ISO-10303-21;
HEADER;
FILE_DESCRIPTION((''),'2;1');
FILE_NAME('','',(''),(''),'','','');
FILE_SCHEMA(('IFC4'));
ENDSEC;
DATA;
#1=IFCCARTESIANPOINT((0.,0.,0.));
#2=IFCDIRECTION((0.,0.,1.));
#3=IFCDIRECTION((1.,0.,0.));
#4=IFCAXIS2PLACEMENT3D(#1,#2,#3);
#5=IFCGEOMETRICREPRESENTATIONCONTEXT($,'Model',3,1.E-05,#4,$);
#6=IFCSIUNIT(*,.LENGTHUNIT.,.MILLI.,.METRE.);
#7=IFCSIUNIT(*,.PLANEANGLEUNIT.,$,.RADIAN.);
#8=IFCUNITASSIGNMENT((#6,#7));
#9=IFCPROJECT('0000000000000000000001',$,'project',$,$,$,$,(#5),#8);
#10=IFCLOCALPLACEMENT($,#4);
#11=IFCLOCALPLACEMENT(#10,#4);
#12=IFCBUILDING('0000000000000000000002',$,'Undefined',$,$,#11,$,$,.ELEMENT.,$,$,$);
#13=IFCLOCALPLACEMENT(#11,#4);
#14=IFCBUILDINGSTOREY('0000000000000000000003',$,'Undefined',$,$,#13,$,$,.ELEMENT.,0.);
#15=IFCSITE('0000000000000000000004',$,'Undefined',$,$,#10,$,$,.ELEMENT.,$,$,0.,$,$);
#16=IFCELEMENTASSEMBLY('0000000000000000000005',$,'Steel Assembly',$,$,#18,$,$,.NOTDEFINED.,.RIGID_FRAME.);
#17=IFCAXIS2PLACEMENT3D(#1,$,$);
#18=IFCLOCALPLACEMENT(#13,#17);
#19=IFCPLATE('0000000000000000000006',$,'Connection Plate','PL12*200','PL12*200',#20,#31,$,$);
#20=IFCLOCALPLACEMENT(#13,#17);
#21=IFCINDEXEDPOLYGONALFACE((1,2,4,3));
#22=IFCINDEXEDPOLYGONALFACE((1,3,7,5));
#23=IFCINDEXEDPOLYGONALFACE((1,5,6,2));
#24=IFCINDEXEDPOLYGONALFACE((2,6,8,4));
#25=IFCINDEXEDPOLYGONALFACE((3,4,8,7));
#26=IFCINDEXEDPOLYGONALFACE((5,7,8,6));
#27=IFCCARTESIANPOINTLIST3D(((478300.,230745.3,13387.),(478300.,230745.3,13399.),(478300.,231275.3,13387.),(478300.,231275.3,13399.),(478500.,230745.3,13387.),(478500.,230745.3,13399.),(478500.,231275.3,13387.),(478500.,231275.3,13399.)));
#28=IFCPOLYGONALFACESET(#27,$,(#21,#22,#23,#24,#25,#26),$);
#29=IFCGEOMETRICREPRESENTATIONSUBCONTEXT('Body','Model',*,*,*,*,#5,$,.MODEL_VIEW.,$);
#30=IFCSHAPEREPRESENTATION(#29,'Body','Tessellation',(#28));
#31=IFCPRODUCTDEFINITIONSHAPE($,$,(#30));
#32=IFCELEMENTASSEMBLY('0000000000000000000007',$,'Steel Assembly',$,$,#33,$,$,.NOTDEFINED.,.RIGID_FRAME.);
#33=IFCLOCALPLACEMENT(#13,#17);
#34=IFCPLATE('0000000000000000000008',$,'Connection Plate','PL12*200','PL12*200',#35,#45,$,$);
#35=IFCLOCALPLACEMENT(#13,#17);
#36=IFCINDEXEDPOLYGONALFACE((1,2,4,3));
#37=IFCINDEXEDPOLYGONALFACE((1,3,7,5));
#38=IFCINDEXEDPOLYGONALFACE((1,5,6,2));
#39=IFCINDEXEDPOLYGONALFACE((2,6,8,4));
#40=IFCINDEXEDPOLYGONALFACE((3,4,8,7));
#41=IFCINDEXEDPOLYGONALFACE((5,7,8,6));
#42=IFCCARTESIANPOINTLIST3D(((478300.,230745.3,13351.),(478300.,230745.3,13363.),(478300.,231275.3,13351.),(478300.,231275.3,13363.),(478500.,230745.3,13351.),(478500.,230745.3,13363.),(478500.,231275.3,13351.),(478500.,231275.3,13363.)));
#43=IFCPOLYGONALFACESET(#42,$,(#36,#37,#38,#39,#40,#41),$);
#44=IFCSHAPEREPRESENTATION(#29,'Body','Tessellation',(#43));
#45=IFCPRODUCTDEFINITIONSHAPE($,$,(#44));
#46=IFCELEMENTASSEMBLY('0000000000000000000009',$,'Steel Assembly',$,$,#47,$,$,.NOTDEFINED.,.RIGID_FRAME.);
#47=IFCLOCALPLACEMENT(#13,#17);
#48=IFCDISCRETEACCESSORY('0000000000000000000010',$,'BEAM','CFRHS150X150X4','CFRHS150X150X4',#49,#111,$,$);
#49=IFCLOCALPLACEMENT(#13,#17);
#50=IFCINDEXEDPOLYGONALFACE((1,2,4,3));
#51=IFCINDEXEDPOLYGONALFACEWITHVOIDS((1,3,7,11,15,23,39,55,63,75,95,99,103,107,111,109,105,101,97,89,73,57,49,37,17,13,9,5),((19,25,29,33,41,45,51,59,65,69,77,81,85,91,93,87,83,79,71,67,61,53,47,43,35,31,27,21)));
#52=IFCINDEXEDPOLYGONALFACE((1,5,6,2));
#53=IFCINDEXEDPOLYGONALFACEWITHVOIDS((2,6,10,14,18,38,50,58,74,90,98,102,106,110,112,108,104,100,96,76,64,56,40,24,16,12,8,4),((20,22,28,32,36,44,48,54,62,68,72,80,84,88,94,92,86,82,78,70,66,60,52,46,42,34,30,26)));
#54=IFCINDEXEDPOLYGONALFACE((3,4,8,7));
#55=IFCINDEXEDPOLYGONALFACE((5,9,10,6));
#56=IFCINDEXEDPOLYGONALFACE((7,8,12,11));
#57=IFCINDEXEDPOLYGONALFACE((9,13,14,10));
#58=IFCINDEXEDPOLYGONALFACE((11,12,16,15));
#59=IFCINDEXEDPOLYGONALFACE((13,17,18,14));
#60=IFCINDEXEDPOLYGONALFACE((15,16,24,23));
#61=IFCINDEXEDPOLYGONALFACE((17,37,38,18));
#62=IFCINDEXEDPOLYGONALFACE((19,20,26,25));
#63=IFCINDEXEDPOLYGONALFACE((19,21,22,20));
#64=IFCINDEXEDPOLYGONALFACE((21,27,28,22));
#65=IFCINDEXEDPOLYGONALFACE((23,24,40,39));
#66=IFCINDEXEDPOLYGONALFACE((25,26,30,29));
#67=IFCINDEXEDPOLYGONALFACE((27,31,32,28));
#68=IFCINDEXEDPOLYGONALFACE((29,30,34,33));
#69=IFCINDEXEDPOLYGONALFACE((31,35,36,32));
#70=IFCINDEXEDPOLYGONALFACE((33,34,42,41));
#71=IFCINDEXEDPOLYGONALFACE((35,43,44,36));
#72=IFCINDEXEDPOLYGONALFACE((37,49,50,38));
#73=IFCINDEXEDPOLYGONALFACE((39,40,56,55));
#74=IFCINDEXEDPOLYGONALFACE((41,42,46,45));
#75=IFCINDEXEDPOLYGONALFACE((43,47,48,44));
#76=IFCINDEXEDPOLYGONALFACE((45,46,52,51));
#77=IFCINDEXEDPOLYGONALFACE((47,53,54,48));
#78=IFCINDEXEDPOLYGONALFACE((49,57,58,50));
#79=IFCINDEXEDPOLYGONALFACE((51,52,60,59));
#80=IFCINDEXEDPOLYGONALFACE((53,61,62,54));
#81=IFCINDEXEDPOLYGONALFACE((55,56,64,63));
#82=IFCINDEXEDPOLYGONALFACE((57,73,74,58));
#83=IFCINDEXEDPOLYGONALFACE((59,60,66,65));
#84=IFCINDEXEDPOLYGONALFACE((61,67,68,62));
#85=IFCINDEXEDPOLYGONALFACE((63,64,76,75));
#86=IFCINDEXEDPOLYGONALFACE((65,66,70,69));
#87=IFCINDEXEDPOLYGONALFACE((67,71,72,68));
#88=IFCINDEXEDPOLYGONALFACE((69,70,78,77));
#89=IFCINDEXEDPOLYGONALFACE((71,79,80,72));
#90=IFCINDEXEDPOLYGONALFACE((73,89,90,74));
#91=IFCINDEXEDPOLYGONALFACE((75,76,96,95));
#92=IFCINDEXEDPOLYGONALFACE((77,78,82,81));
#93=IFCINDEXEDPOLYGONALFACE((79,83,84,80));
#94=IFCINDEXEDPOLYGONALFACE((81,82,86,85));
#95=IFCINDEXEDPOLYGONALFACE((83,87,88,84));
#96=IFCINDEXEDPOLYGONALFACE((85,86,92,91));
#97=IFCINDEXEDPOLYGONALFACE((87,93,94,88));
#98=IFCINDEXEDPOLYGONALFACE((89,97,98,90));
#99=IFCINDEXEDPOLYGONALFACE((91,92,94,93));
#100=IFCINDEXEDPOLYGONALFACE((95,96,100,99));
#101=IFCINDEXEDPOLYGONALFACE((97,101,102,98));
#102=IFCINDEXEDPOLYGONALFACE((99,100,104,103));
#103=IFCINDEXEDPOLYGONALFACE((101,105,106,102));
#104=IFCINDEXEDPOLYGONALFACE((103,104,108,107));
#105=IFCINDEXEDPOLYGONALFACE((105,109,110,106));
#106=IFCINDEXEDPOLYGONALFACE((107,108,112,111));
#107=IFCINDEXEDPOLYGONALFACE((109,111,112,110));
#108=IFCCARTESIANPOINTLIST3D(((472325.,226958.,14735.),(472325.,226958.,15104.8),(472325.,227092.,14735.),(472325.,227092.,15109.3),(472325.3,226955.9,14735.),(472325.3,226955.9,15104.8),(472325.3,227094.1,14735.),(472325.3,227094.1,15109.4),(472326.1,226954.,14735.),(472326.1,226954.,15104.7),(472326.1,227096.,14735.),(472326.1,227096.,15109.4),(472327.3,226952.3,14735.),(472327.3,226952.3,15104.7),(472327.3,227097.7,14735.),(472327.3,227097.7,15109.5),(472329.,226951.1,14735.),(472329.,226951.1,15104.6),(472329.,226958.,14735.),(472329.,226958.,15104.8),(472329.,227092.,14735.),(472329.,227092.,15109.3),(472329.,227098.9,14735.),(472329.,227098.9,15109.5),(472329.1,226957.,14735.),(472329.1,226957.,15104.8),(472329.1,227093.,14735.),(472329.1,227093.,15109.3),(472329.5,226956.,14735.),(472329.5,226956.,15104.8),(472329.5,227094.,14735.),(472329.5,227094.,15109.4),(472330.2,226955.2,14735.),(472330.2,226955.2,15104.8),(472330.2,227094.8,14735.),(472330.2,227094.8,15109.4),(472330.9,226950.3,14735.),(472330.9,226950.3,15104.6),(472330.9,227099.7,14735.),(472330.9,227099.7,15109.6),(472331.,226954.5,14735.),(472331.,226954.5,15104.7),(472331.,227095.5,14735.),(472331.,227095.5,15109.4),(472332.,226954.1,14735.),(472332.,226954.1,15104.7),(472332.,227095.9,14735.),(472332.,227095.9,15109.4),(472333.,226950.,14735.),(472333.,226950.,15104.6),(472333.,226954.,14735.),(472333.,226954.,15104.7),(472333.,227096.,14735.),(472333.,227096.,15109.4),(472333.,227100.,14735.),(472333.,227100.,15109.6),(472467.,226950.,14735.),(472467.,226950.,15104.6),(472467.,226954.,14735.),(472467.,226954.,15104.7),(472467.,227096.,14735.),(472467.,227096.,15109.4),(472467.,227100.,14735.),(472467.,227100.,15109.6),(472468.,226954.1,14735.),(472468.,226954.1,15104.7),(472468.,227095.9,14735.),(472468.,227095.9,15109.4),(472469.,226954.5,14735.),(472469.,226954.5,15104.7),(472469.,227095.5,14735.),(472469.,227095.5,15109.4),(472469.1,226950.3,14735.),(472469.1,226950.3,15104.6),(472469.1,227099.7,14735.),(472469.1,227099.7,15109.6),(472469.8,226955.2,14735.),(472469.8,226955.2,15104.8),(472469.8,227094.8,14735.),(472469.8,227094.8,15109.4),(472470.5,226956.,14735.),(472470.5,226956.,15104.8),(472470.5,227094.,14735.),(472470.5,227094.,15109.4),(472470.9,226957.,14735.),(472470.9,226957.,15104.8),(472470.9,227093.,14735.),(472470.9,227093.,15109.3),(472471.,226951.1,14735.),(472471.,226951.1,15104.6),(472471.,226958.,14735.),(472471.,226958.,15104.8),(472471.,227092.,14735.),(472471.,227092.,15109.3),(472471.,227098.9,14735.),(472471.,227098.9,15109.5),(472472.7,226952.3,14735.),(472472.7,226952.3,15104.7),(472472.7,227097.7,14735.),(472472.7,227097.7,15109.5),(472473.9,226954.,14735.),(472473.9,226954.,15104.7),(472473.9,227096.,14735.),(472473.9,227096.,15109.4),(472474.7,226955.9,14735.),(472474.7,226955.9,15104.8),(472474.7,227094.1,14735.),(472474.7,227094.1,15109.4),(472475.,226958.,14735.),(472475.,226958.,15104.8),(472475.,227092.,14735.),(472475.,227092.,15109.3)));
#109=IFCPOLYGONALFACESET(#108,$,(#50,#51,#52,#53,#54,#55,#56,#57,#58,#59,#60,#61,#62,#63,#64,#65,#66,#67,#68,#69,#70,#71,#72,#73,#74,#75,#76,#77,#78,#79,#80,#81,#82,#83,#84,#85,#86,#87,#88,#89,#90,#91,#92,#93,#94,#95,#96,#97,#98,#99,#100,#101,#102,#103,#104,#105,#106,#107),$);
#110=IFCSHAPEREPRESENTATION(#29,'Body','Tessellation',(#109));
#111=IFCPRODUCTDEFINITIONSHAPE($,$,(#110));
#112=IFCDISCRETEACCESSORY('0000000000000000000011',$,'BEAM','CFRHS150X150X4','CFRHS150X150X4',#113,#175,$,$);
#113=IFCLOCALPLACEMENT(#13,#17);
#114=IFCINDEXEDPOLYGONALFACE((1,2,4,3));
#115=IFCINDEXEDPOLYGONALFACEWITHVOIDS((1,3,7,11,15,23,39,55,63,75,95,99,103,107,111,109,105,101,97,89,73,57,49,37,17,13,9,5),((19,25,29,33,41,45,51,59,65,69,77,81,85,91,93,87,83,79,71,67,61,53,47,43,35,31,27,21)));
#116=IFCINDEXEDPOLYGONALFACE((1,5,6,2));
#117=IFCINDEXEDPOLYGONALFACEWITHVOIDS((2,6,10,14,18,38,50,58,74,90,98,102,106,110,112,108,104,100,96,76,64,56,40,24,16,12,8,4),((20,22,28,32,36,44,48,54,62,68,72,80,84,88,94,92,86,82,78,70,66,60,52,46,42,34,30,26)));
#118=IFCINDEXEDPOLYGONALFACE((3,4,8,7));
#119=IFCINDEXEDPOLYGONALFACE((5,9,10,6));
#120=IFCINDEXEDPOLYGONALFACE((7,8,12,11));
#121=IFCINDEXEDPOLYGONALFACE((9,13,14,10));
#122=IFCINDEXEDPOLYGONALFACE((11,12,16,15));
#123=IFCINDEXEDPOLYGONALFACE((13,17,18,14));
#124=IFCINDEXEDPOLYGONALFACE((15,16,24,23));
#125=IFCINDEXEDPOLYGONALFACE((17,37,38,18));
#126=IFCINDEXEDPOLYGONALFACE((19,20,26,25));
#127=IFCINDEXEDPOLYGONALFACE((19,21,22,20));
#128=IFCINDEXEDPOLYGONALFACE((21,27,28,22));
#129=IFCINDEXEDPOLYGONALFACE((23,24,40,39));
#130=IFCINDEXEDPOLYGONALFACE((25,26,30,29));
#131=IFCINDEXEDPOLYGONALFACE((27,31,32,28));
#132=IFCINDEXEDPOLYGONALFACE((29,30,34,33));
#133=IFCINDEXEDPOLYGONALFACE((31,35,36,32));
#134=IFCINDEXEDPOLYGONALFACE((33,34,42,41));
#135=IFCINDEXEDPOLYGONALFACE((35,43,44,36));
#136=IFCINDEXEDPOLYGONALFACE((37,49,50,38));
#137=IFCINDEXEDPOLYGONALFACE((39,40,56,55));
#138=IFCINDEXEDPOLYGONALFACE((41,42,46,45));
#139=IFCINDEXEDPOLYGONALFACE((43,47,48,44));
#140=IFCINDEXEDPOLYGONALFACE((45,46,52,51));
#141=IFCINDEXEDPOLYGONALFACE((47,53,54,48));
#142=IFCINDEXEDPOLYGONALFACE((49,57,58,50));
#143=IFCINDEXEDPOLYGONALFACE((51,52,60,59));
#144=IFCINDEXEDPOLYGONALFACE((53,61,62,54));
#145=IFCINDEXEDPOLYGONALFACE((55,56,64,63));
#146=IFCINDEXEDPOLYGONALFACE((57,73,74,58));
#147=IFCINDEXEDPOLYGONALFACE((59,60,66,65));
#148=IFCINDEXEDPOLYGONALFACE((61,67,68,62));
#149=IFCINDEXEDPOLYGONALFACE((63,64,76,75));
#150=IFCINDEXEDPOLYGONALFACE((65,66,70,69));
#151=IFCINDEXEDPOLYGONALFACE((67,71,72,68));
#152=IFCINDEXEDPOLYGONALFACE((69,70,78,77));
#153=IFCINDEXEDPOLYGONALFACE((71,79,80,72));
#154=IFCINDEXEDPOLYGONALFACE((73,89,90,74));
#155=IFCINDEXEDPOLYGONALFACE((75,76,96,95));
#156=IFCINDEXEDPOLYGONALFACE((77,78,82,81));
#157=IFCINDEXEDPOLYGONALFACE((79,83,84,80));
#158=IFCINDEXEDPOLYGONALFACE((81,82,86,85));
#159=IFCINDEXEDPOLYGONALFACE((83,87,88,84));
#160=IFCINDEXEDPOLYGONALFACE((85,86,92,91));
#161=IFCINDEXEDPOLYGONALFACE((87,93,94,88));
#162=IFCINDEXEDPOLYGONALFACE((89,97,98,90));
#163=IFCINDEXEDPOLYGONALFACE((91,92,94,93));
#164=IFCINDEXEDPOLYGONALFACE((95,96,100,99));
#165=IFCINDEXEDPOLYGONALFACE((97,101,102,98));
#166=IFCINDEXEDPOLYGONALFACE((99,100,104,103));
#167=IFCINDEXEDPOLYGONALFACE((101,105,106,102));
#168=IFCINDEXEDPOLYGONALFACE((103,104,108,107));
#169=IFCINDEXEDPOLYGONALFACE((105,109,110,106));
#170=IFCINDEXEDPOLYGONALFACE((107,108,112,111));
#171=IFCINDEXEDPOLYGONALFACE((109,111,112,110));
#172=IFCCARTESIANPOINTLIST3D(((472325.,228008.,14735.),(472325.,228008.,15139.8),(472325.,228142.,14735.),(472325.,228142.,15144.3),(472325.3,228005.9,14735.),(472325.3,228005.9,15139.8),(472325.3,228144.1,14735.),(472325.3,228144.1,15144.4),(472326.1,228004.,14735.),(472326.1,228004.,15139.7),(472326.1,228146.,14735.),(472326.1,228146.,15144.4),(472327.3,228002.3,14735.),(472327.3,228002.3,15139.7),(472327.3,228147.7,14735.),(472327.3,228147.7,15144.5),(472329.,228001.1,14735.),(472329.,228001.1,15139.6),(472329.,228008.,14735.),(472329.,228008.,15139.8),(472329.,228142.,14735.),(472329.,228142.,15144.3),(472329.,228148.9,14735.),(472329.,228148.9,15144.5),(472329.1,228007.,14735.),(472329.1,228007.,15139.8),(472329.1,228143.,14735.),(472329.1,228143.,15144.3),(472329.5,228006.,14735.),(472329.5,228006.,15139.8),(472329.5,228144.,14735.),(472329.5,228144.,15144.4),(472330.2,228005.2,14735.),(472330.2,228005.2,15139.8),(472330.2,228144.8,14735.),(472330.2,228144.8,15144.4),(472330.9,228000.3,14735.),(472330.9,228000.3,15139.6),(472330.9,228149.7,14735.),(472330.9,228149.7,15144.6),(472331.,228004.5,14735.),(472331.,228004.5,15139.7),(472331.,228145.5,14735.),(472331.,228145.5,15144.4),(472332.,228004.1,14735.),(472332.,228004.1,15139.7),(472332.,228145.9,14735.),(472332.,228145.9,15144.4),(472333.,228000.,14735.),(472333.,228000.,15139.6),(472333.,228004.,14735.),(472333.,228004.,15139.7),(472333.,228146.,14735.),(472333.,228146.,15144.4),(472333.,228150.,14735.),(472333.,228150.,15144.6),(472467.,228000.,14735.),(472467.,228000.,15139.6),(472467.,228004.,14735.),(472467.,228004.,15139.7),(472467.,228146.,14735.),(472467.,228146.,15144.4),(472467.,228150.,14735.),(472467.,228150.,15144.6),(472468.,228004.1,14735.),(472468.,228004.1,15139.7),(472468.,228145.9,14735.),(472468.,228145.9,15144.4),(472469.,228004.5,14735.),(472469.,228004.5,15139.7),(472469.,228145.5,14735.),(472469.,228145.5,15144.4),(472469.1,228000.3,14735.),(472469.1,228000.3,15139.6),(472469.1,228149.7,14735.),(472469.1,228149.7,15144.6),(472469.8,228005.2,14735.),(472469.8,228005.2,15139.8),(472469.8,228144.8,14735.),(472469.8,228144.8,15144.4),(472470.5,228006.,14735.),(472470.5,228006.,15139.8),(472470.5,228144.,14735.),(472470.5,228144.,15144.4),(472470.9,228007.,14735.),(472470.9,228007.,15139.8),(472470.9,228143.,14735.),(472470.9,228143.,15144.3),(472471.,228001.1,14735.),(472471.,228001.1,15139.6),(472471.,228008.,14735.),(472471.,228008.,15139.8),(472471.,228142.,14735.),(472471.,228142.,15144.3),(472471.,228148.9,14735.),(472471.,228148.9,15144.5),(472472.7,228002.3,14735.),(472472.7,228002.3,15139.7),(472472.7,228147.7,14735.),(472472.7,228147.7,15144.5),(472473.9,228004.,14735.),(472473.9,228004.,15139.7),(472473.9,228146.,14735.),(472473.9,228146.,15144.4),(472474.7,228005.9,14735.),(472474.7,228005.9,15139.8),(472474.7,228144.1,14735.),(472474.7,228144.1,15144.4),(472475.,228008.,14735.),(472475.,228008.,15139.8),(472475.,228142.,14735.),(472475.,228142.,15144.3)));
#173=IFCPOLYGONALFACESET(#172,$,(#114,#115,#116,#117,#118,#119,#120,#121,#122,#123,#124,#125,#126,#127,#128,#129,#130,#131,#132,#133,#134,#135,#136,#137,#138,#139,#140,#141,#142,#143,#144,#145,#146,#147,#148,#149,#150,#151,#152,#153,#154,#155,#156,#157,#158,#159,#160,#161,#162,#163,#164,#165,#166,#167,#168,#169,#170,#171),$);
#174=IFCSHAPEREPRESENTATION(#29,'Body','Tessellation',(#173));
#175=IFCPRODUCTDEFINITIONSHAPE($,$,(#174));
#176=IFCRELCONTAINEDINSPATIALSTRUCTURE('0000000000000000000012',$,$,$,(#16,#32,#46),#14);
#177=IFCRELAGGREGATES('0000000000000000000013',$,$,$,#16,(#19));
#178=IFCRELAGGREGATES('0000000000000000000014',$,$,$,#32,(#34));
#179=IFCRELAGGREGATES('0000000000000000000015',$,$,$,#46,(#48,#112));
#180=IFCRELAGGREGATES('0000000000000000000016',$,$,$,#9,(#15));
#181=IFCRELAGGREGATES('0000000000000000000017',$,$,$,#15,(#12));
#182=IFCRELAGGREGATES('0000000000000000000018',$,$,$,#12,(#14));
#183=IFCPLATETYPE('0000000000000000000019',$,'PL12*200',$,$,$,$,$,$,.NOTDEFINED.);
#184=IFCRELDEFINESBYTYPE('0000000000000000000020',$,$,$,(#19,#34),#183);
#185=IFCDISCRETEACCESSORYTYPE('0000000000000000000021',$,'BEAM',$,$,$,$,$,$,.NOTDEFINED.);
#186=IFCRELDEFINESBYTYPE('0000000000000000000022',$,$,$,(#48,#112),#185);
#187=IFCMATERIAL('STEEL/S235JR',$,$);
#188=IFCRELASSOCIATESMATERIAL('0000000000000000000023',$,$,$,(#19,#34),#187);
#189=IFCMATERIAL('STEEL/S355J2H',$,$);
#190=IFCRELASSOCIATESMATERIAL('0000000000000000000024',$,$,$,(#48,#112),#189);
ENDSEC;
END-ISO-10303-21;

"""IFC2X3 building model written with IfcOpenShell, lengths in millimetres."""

from ifc_helpers import new_model, si_unit, frame, origin_with_axes, origin_2d_with_axis, place, context, subcontext, project, spatial, polyline, hollow_rectangle, outline, extrude, clip, halfspace, material, type_object, element, aggregate, save


model = new_model("IFC2X3")

# Units and contexts
model_context = context("Model", 3, precision=1e-05, world=origin_with_axes())
body_context = subcontext(model_context, "Body", "Model", "MODEL_VIEW")
ifc_project = project(units=[si_unit("LENGTHUNIT", "METRE", prefix="MILLI"), si_unit("PLANEANGLEUNIT", "RADIAN")], contexts=[model_context])

# Site, building, storey
site_placement = place(None, origin_with_axes())
site = spatial("IfcSite", under=ifc_project, at=site_placement, Name="Undefined", CompositionType="ELEMENT", RefElevation=0.0)
building_placement = place(site_placement, origin_with_axes())
building = spatial("IfcBuilding", under=site, at=building_placement, Name="Undefined", CompositionType="ELEMENT")
storey_placement = place(building_placement, origin_with_axes())
storey = spatial("IfcBuildingStorey", under=building, at=storey_placement, Name="Undefined", CompositionType="ELEMENT", Elevation=0.0)

# Shared definitions
ifc_material_1 = material(Name="STEEL/S235JR")

# Element assemblies, plates
assembly_1_placement = place(storey_placement, origin_with_axes())
assembly_1 = element("IfcElementAssembly", 1, at=assembly_1_placement, inside=storey, Name="Steel Assembly", AssemblyPlace="NOTDEFINED", PredefinedType="RIGID_FRAME")
plate_type = type_object("IfcPlateType", Name="PL12*200", PredefinedType="NOTDEFINED")
plate_1_placement = place(assembly_1_placement, frame((478500.0, 231275.3, 13393.0), z_axis=(0.0, 0.0, -1.0), x_axis=(0.0, -1.0, 0.0)))
plate_1 = element("IfcPlate", 2, at=plate_1_placement, type_object=plate_type, material=ifc_material_1, Name="Connection Plate", Description="PL12*200", ObjectType="PL12*200", context=body_context, shape_type="SweptSolid", body=[
    extrude(outline(polyline([(0.0, 0.0), (530.0, 0.0), (530.0, 200.0), (0.0, 200.0), (0.0, 0.0)])), frame((0.0, 0.0, -6.0), z_axis=(0.0, 0.0, 1.0), x_axis=(1.0, 0.0, 0.0)), (0.0, 0.0, 1.0), 12.0),
])
aggregate(assembly_1, [plate_1])
assembly_2_placement = place(storey_placement, origin_with_axes())
assembly_2 = element("IfcElementAssembly", 3, at=assembly_2_placement, inside=storey, Name="Steel Assembly", AssemblyPlace="NOTDEFINED", PredefinedType="RIGID_FRAME")
plate_2_placement = place(assembly_2_placement, frame((478500.0, 231275.3, 13357.0), z_axis=(0.0, 0.0, -1.0), x_axis=(0.0, -1.0, 0.0)))
plate_2 = element("IfcPlate", 4, at=plate_2_placement, type_object=plate_type, material=ifc_material_1, Name="Connection Plate", Description="PL12*200", ObjectType="PL12*200", context=body_context, shape_type="SweptSolid", body=[
    extrude(outline(polyline([(0.0, 0.0), (530.0, 0.0), (530.0, 200.0), (0.0, 200.0), (0.0, 0.0)])), frame((0.0, 0.0, -6.0), z_axis=(0.0, 0.0, 1.0), x_axis=(1.0, 0.0, 0.0)), (0.0, 0.0, 1.0), 12.0),
])
aggregate(assembly_2, [plate_2])

# Element assembly, discrete accessories
ifc_material_2 = material(Name="STEEL/S355J2H")
assembly_3_placement = place(storey_placement, origin_with_axes())
assembly_3 = element("IfcElementAssembly", 5, at=assembly_3_placement, inside=storey, Name="Steel Assembly", AssemblyPlace="NOTDEFINED", PredefinedType="RIGID_FRAME")
discrete_accessory_type_1 = type_object("IfcDiscreteAccessoryType", Name="BEAM")
discrete_accessory_1_placement = place(assembly_3_placement, frame((472400.0, 227025.0, 14720.0), z_axis=(0.0, 0.0, 1.0), x_axis=(1.0, 0.0, 0.0)))
discrete_accessory_1 = element("IfcDiscreteAccessory", 6, at=discrete_accessory_1_placement, type_object=discrete_accessory_type_1, material=ifc_material_2, Name="BEAM", Description="CFRHS150X150X4", ObjectType="CFRHS150X150X4", context=body_context, shape_type="Clipping", body=[
    clip(extrude(hollow_rectangle(XDim=150.0, YDim=150.0, WallThickness=4.0, InnerFilletRadius=4.0, OuterFilletRadius=8.0, at=origin_2d_with_axis()), frame((0.0, 0.0, 389.6), z_axis=(0.0, 0.0, -1.0), x_axis=(0.0, -1.0, 0.0)), (0.0, 0.0, 1.0), 374.6), halfspace(frame((-1000.0, 2.7, 387.2), z_axis=(0.0, 0.033315, -0.999445), x_axis=(0.0, -0.999445, -0.033315)), True)),
])
discrete_accessory_2_placement = place(assembly_3_placement, frame((472400.0, 228075.0, 14720.0), z_axis=(0.0, 0.0, 1.0), x_axis=(1.0, 0.0, 0.0)))
discrete_accessory_2 = element("IfcDiscreteAccessory", 7, at=discrete_accessory_2_placement, type_object=discrete_accessory_type_1, material=ifc_material_2, Name="BEAM", Description="CFRHS150X150X4", ObjectType="CFRHS150X150X4", context=body_context, shape_type="Clipping", body=[
    clip(extrude(hollow_rectangle(XDim=150.0, YDim=150.0, WallThickness=4.0, InnerFilletRadius=4.0, OuterFilletRadius=8.0, at=origin_2d_with_axis()), frame((0.0, 0.0, 424.6), z_axis=(0.0, 0.0, -1.0), x_axis=(0.0, -1.0, 0.0)), (0.0, 0.0, 1.0), 409.6), halfspace(frame((-1000.0, 2.7, 422.2), z_axis=(0.0, 0.033315, -0.999445), x_axis=(0.0, -0.999445, -0.033315)), True)),
])

aggregate(assembly_3, [discrete_accessory_1, discrete_accessory_2])

save(model, "model.ifc")
